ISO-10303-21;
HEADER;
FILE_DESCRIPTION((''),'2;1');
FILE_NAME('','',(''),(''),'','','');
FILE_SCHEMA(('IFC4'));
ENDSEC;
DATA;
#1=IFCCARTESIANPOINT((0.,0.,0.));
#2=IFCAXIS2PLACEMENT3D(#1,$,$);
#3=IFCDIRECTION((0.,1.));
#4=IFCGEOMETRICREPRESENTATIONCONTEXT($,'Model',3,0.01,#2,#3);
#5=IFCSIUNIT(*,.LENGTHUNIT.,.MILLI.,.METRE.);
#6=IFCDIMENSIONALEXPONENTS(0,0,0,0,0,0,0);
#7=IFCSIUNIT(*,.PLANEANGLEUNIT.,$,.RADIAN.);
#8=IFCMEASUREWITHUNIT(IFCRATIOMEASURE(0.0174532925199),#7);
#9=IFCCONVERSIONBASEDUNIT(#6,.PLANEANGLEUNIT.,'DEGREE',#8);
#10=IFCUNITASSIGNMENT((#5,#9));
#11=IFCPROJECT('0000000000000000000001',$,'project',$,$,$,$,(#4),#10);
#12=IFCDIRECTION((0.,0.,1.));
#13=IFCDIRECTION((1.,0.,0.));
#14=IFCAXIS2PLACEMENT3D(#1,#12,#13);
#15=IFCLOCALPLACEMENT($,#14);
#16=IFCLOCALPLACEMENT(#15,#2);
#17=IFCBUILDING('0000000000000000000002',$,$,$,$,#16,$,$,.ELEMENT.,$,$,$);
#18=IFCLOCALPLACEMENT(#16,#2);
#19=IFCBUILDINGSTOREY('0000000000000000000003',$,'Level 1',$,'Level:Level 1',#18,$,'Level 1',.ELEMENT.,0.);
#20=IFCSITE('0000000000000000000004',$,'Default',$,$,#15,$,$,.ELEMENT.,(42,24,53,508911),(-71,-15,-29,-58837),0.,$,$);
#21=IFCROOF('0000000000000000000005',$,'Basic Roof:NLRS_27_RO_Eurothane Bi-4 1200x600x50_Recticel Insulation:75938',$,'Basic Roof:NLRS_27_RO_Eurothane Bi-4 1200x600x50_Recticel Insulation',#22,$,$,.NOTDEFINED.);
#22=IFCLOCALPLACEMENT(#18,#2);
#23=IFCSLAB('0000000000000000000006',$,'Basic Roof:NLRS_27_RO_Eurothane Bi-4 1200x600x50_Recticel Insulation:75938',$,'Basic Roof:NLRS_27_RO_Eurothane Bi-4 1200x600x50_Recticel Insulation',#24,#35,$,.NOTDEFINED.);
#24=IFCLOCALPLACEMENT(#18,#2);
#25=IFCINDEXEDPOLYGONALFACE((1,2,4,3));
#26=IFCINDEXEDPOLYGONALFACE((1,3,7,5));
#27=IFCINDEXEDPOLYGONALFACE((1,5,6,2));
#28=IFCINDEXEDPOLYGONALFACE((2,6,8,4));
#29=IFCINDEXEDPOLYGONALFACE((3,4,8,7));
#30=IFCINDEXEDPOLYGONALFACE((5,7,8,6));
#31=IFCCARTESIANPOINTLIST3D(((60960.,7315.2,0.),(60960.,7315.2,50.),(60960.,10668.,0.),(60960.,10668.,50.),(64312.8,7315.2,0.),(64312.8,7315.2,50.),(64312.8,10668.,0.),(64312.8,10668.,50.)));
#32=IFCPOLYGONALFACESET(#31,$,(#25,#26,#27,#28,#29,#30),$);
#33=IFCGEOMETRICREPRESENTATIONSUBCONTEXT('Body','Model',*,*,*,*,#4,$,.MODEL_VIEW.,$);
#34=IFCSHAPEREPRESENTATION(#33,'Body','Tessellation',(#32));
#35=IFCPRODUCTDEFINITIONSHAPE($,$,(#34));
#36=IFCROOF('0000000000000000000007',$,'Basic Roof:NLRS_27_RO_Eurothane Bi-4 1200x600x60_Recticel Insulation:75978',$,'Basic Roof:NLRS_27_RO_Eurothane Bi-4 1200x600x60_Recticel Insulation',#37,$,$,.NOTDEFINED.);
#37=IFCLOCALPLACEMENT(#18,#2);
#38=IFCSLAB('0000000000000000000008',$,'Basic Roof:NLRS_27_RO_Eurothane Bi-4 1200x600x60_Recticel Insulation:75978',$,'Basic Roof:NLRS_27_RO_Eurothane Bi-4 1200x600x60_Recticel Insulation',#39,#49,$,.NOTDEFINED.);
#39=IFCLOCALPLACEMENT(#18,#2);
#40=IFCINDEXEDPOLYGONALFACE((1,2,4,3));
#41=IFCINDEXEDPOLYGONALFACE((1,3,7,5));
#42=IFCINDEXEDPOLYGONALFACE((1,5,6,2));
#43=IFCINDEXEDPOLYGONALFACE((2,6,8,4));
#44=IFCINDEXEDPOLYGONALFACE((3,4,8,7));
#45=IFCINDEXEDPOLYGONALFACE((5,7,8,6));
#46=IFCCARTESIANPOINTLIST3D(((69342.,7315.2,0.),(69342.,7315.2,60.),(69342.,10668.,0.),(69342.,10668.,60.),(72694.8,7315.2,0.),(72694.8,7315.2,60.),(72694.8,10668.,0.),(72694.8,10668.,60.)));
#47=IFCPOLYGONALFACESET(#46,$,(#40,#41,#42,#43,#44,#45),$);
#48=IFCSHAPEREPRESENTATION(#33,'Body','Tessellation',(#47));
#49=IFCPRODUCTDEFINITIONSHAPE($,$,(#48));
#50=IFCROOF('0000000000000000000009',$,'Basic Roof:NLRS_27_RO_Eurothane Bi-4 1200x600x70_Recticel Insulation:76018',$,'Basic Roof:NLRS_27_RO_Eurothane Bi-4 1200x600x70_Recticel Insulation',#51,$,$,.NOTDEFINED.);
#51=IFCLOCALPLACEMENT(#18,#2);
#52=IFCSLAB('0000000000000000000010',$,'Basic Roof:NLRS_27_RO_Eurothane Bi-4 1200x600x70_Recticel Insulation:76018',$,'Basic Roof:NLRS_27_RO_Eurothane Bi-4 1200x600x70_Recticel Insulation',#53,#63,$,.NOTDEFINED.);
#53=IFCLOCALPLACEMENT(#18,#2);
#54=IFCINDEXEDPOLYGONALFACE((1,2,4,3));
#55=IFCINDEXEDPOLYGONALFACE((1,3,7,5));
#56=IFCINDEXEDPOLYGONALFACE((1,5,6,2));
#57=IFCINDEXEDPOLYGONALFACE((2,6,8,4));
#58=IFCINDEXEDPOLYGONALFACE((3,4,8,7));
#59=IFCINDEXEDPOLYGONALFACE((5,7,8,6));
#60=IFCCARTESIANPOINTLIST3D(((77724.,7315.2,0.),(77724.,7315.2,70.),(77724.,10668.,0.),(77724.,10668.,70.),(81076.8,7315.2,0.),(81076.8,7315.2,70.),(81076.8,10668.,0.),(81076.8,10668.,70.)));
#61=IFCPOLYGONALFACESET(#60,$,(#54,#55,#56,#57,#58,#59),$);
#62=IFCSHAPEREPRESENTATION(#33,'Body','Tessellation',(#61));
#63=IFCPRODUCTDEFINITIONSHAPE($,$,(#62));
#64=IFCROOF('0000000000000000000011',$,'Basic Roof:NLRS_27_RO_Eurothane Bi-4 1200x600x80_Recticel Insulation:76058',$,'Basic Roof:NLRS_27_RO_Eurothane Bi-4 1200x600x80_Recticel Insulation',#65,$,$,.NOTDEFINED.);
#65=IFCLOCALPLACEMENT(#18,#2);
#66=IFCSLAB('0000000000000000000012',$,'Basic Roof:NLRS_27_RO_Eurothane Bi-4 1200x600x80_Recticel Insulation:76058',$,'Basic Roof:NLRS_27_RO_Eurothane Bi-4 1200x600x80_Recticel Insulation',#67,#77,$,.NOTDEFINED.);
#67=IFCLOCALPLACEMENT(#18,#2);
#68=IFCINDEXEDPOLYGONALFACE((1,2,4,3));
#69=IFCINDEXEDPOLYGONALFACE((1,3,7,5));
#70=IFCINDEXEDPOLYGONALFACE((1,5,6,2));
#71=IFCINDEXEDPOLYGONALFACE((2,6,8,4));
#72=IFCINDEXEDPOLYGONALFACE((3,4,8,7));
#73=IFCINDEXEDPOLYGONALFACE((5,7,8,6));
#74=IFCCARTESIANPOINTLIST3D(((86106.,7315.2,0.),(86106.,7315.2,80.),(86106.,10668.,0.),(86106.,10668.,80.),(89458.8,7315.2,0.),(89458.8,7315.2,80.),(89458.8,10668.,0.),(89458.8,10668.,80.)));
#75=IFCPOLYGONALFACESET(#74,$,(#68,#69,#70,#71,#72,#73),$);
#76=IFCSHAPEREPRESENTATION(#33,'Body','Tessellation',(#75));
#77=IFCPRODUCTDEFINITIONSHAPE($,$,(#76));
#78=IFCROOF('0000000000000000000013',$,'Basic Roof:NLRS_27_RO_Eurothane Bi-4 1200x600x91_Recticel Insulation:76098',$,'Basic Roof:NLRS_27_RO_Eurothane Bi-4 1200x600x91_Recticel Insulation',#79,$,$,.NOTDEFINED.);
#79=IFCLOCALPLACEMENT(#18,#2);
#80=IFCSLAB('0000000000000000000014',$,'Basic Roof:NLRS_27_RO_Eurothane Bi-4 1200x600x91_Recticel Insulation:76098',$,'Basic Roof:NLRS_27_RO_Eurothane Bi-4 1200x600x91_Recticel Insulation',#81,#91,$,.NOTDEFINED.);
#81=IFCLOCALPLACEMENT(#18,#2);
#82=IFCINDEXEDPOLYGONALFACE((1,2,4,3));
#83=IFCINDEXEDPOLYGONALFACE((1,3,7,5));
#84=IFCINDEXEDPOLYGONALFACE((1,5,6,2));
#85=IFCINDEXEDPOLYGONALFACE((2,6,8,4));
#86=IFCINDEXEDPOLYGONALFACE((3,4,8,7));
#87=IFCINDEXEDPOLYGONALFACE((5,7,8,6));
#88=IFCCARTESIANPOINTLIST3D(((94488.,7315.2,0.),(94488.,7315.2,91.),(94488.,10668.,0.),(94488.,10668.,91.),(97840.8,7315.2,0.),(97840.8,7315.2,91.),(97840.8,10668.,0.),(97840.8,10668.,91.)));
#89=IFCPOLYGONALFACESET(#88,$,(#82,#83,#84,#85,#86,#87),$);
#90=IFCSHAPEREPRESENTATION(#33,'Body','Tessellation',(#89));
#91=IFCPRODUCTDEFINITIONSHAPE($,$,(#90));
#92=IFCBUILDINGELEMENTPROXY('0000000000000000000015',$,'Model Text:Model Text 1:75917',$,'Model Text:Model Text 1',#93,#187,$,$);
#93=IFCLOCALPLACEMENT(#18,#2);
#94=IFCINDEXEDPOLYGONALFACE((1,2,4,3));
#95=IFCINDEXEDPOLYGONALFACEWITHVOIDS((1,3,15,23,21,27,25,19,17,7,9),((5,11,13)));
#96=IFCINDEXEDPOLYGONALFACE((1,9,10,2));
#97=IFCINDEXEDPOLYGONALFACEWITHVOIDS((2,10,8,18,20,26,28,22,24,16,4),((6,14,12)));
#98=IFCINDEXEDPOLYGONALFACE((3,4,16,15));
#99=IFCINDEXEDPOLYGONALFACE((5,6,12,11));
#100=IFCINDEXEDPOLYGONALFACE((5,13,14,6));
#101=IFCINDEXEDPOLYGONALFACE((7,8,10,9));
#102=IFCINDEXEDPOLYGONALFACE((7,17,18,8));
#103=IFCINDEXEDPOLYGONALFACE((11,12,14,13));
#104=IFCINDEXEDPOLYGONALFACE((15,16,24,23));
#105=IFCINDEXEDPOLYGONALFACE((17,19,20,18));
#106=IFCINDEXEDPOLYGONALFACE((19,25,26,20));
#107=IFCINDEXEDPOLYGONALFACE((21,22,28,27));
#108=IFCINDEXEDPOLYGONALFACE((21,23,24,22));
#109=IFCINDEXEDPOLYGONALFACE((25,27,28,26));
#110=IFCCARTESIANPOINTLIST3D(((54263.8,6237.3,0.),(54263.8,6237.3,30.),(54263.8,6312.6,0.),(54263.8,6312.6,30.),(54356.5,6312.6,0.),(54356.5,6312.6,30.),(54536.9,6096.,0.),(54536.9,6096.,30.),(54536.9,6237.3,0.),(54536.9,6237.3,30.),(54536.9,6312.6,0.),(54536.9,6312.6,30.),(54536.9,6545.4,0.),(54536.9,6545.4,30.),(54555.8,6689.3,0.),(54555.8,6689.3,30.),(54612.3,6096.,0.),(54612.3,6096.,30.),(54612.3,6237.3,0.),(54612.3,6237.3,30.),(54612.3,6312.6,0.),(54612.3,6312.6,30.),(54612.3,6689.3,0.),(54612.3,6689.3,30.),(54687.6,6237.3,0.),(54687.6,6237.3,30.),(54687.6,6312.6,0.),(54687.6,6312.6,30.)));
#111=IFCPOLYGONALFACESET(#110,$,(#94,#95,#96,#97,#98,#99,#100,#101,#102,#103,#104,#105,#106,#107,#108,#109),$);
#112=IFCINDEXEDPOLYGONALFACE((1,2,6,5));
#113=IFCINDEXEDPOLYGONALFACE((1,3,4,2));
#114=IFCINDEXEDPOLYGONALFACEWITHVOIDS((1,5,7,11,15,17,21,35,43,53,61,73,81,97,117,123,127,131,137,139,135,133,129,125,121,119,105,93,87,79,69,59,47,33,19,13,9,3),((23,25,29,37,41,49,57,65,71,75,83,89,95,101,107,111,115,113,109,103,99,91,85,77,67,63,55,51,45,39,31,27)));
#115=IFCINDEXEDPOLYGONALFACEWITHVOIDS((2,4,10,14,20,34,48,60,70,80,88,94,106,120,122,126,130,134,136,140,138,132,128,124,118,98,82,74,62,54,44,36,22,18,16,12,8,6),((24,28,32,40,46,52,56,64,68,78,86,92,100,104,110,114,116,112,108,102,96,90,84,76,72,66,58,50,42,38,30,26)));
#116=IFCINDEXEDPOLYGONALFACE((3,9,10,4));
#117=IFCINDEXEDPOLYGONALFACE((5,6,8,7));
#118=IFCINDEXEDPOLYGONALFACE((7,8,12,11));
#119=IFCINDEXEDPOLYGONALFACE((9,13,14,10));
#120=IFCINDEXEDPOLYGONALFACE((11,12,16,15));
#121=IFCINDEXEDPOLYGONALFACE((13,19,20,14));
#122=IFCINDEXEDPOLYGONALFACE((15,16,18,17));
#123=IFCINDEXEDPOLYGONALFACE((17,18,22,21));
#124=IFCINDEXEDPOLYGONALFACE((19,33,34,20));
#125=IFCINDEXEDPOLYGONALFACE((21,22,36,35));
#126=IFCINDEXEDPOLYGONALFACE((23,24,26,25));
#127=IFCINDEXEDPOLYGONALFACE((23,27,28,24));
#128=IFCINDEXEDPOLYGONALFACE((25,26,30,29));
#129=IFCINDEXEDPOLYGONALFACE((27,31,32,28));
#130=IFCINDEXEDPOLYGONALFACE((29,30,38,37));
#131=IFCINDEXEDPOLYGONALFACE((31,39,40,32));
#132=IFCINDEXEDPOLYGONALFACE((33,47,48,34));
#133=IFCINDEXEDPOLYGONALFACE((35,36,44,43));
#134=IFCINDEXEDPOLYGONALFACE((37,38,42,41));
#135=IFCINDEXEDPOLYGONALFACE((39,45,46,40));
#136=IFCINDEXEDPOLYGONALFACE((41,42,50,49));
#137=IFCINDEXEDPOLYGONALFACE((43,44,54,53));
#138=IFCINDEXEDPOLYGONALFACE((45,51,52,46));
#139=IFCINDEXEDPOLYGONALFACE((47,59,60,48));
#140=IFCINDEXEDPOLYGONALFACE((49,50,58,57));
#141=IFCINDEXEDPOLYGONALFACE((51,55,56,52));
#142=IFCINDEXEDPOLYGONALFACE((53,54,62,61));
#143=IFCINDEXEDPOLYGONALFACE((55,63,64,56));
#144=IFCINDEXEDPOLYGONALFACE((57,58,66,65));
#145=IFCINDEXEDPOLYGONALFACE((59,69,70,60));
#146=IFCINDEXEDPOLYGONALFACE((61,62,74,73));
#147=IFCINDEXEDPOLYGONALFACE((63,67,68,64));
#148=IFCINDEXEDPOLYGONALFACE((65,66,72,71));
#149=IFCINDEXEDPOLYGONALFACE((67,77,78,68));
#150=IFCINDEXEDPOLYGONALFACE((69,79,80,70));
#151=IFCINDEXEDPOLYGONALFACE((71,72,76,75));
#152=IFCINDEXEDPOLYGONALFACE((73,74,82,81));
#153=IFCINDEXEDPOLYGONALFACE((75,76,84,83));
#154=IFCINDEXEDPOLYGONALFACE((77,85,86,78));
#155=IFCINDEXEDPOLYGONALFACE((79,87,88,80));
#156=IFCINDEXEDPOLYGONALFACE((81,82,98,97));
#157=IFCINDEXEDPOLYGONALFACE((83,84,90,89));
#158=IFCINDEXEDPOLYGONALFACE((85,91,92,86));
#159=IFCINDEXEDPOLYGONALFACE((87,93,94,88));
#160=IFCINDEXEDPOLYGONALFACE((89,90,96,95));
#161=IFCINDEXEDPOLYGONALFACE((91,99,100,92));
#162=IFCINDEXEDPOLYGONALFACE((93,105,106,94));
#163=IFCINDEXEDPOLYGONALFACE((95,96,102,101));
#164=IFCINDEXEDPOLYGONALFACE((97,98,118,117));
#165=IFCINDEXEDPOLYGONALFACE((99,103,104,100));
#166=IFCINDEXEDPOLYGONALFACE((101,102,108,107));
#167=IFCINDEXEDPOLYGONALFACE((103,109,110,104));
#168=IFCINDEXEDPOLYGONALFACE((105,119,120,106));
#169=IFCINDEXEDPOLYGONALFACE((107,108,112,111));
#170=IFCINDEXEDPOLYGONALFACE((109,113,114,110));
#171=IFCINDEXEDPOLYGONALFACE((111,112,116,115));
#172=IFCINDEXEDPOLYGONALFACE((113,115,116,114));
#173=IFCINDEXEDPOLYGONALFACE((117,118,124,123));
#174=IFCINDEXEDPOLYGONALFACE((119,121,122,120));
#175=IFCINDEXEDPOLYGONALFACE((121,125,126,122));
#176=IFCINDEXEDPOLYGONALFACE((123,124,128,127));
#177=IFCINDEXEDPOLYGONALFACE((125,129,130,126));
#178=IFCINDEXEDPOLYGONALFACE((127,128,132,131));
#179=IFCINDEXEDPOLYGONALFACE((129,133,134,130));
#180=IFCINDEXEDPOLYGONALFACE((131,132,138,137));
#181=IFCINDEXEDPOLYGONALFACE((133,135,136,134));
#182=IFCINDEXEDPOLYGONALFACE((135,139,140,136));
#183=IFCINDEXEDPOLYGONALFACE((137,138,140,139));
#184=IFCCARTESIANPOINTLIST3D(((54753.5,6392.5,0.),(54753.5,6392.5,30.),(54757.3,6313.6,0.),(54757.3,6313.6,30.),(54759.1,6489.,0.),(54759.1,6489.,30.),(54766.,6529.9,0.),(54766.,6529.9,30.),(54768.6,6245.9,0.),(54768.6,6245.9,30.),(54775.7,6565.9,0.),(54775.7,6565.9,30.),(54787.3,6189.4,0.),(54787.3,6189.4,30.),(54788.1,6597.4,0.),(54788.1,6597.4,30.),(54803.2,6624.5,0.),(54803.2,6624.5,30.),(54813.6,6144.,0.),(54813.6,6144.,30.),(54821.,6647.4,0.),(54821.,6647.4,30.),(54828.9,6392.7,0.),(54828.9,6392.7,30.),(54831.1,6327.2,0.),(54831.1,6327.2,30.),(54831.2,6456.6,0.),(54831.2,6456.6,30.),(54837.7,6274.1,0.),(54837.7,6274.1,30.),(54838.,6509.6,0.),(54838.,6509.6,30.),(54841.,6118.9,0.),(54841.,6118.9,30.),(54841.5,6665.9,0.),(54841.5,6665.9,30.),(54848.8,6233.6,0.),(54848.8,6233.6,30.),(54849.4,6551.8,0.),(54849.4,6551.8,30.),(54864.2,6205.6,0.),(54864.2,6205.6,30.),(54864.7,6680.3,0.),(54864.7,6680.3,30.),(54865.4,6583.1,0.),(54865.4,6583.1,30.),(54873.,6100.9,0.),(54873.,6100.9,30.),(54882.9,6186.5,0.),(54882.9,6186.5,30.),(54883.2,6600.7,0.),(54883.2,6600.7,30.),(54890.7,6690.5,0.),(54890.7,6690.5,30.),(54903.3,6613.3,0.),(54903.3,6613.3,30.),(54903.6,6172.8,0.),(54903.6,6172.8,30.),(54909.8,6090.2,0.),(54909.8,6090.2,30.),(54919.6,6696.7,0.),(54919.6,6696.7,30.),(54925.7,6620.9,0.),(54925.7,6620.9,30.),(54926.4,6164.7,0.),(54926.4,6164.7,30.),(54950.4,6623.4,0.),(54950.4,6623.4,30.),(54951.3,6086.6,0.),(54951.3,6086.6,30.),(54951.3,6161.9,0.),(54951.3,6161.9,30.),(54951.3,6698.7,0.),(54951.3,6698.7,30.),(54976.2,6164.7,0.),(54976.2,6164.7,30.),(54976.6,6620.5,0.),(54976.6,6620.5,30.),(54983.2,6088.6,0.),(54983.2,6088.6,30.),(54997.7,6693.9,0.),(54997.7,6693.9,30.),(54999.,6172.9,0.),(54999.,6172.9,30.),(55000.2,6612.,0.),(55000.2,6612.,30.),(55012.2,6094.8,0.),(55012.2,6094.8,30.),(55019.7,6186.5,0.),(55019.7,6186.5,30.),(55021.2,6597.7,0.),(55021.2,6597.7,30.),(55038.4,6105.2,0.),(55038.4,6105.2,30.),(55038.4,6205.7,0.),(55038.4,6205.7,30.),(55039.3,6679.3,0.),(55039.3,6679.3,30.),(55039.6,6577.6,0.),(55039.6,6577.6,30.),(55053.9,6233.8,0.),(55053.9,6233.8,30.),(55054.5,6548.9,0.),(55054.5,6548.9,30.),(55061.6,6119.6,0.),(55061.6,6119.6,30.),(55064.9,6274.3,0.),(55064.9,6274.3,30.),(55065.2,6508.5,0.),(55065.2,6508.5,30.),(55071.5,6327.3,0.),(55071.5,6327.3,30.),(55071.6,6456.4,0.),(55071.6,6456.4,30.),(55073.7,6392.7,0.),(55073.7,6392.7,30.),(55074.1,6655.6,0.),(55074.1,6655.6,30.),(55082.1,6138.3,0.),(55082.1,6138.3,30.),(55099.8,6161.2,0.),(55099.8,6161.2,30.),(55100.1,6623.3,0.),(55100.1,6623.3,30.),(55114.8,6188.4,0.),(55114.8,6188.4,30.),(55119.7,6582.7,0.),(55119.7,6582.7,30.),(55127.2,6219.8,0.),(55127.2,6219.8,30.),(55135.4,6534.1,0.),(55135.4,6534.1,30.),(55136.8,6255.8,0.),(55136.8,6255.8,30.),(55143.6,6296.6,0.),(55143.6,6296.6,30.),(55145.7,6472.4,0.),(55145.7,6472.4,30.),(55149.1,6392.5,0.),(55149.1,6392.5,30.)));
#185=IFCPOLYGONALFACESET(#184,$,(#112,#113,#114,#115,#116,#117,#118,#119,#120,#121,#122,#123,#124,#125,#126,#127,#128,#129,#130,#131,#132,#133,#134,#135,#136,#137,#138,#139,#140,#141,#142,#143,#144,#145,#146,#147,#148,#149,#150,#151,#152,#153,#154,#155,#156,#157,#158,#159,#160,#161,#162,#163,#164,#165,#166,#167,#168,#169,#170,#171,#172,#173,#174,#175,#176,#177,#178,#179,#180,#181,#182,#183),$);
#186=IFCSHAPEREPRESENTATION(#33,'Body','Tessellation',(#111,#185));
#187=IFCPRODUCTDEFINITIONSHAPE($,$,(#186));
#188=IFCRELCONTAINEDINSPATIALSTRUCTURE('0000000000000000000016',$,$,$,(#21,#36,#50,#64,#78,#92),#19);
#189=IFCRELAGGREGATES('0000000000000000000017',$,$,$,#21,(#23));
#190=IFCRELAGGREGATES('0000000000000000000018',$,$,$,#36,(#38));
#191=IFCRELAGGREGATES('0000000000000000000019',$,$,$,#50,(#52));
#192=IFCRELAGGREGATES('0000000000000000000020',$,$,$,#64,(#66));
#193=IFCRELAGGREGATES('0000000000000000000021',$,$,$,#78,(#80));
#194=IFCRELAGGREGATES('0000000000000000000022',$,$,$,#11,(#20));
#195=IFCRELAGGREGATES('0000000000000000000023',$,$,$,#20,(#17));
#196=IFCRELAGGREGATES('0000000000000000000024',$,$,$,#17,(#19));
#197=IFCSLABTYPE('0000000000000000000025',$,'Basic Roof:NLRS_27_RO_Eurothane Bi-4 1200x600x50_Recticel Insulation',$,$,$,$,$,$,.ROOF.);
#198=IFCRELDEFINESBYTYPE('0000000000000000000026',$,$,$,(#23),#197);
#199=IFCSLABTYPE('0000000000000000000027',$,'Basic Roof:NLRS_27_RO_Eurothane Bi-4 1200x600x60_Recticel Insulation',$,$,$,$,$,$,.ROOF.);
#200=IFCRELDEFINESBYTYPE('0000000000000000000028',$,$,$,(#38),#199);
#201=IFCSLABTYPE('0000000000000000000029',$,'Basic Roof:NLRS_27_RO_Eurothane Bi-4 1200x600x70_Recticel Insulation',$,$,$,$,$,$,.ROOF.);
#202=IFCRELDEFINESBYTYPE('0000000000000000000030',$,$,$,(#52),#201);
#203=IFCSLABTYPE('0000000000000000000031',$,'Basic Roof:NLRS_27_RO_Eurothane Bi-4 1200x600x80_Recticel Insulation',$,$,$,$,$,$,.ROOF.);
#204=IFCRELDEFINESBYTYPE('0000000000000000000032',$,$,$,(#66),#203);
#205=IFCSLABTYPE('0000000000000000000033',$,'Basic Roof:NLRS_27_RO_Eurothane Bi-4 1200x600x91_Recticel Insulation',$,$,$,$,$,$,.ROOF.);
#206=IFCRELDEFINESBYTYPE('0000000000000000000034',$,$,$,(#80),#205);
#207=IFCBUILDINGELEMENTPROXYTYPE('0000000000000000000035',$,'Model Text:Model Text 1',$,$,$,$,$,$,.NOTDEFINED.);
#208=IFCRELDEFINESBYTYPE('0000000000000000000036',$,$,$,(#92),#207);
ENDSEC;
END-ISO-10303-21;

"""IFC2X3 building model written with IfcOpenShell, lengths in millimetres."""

from ifc_helpers import new_model, entity, si_unit, converted_unit, direction, frame, origin, origin_with_axes, origin_2d_with_axis, place, context, subcontext, project, spatial, polyline, rectangle, outline, extrude, type_object, element, aggregate, save


model = new_model("IFC2X3")

# Units and contexts
model_context = context("Model", 3, precision=0.01, world=origin(), true_north=direction((0.0, 1.0)))
body_context = subcontext(model_context, "Body", "Model", "MODEL_VIEW")
ifc_project = project(units=[si_unit("LENGTHUNIT", "METRE", prefix="MILLI"), converted_unit("PLANEANGLEUNIT", "DEGREE", entity("IfcRatioMeasure", 0.0174532925199), si_unit("PLANEANGLEUNIT", "RADIAN"), dimensions=[0, 0, 0, 0, 0, 0, 0])], contexts=[model_context])

# Site, building, storey
site_placement = place(None, origin_with_axes())
site = spatial("IfcSite", under=ifc_project, at=site_placement, Name="Default", CompositionType="ELEMENT", RefLatitude=(42, 24, 53, 508911), RefLongitude=(-71, -15, -29, -58837), RefElevation=0.0)
building_placement = place(site_placement, origin())
building = spatial("IfcBuilding", under=site, at=building_placement, CompositionType="ELEMENT")
storey_placement = place(building_placement, origin())
storey = spatial("IfcBuildingStorey", under=building, at=storey_placement, Name="Level 1", ObjectType="Level:Level 1", LongName="Level 1", CompositionType="ELEMENT", Elevation=0.0)

# Roofs, slabs
roof_1_placement = place(storey_placement, frame((60960.0, 7315.2, 0.0)))
roof_1 = element("IfcRoof", 1, at=roof_1_placement, inside=storey, Name="Basic Roof:NLRS_27_RO_Eurothane Bi-4 1200x600x50_Recticel Insulation:75938", ObjectType="Basic Roof:NLRS_27_RO_Eurothane Bi-4 1200x600x50_Recticel Insulation", ShapeType="NOTDEFINED")
slab_type_1 = type_object("IfcSlabType", Name="Basic Roof:NLRS_27_RO_Eurothane Bi-4 1200x600x50_Recticel Insulation", PredefinedType="ROOF")
slab_1_placement = place(roof_1_placement, origin())
slab_1 = element("IfcSlab", 2, at=slab_1_placement, type_object=slab_type_1, Name="Basic Roof:NLRS_27_RO_Eurothane Bi-4 1200x600x50_Recticel Insulation:75938", ObjectType="Basic Roof:NLRS_27_RO_Eurothane Bi-4 1200x600x50_Recticel Insulation", PredefinedType="NOTDEFINED", context=body_context, shape_type="SweptSolid", body=[
    extrude(rectangle(XDim=3352.8, YDim=3352.8, at=origin_2d_with_axis()), frame((1676.4, 1676.4, 0.0), x_axis=(-1.0, 0.0, 0.0)), (0.0, 0.0, 1.0), 50.0),
])
aggregate(roof_1, [slab_1])
roof_2_placement = place(storey_placement, frame((69342.0, 7315.2, 0.0)))
roof_2 = element("IfcRoof", 3, at=roof_2_placement, inside=storey, Name="Basic Roof:NLRS_27_RO_Eurothane Bi-4 1200x600x60_Recticel Insulation:75978", ObjectType="Basic Roof:NLRS_27_RO_Eurothane Bi-4 1200x600x60_Recticel Insulation", ShapeType="NOTDEFINED")
slab_type_2 = type_object("IfcSlabType", Name="Basic Roof:NLRS_27_RO_Eurothane Bi-4 1200x600x60_Recticel Insulation", PredefinedType="ROOF")
slab_2_placement = place(roof_2_placement, origin())
slab_2 = element("IfcSlab", 4, at=slab_2_placement, type_object=slab_type_2, Name="Basic Roof:NLRS_27_RO_Eurothane Bi-4 1200x600x60_Recticel Insulation:75978", ObjectType="Basic Roof:NLRS_27_RO_Eurothane Bi-4 1200x600x60_Recticel Insulation", PredefinedType="NOTDEFINED", context=body_context, shape_type="SweptSolid", body=[
    extrude(rectangle(XDim=3352.8, YDim=3352.8, at=origin_2d_with_axis()), frame((1676.4, 1676.4, 0.0), x_axis=(-1.0, 0.0, 0.0)), (0.0, 0.0, 1.0), 60.0),
])
aggregate(roof_2, [slab_2])
roof_3_placement = place(storey_placement, frame((77724.0, 7315.2, 0.0)))
roof_3 = element("IfcRoof", 5, at=roof_3_placement, inside=storey, Name="Basic Roof:NLRS_27_RO_Eurothane Bi-4 1200x600x70_Recticel Insulation:76018", ObjectType="Basic Roof:NLRS_27_RO_Eurothane Bi-4 1200x600x70_Recticel Insulation", ShapeType="NOTDEFINED")
slab_type_3 = type_object("IfcSlabType", Name="Basic Roof:NLRS_27_RO_Eurothane Bi-4 1200x600x70_Recticel Insulation", PredefinedType="ROOF")
slab_3_placement = place(roof_3_placement, origin())
slab_3 = element("IfcSlab", 6, at=slab_3_placement, type_object=slab_type_3, Name="Basic Roof:NLRS_27_RO_Eurothane Bi-4 1200x600x70_Recticel Insulation:76018", ObjectType="Basic Roof:NLRS_27_RO_Eurothane Bi-4 1200x600x70_Recticel Insulation", PredefinedType="NOTDEFINED", context=body_context, shape_type="SweptSolid", body=[
    extrude(rectangle(XDim=3352.8, YDim=3352.8, at=origin_2d_with_axis()), frame((1676.4, 1676.4, 0.0), x_axis=(-1.0, 0.0, 0.0)), (0.0, 0.0, 1.0), 70.0),
])
aggregate(roof_3, [slab_3])
roof_4_placement = place(storey_placement, frame((86106.0, 7315.2, 0.0)))
roof_4 = element("IfcRoof", 7, at=roof_4_placement, inside=storey, Name="Basic Roof:NLRS_27_RO_Eurothane Bi-4 1200x600x80_Recticel Insulation:76058", ObjectType="Basic Roof:NLRS_27_RO_Eurothane Bi-4 1200x600x80_Recticel Insulation", ShapeType="NOTDEFINED")
slab_type_4 = type_object("IfcSlabType", Name="Basic Roof:NLRS_27_RO_Eurothane Bi-4 1200x600x80_Recticel Insulation", PredefinedType="ROOF")
slab_4_placement = place(roof_4_placement, origin())
slab_4 = element("IfcSlab", 8, at=slab_4_placement, type_object=slab_type_4, Name="Basic Roof:NLRS_27_RO_Eurothane Bi-4 1200x600x80_Recticel Insulation:76058", ObjectType="Basic Roof:NLRS_27_RO_Eurothane Bi-4 1200x600x80_Recticel Insulation", PredefinedType="NOTDEFINED", context=body_context, shape_type="SweptSolid", body=[
    extrude(rectangle(XDim=3352.8, YDim=3352.8, at=origin_2d_with_axis()), frame((1676.4, 1676.4, 0.0), x_axis=(-1.0, 0.0, 0.0)), (0.0, 0.0, 1.0), 80.0),
])
aggregate(roof_4, [slab_4])
roof_5_placement = place(storey_placement, frame((94488.0, 7315.2, 0.0)))
roof_5 = element("IfcRoof", 9, at=roof_5_placement, inside=storey, Name="Basic Roof:NLRS_27_RO_Eurothane Bi-4 1200x600x91_Recticel Insulation:76098", ObjectType="Basic Roof:NLRS_27_RO_Eurothane Bi-4 1200x600x91_Recticel Insulation", ShapeType="NOTDEFINED")
slab_type_5 = type_object("IfcSlabType", Name="Basic Roof:NLRS_27_RO_Eurothane Bi-4 1200x600x91_Recticel Insulation", PredefinedType="ROOF")
slab_5_placement = place(roof_5_placement, origin())
slab_5 = element("IfcSlab", 10, at=slab_5_placement, type_object=slab_type_5, Name="Basic Roof:NLRS_27_RO_Eurothane Bi-4 1200x600x91_Recticel Insulation:76098", ObjectType="Basic Roof:NLRS_27_RO_Eurothane Bi-4 1200x600x91_Recticel Insulation", PredefinedType="NOTDEFINED", context=body_context, shape_type="SweptSolid", body=[
    extrude(rectangle(XDim=3352.8, YDim=3352.8, at=origin_2d_with_axis()), frame((1676.4, 1676.4, 0.0), x_axis=(-1.0, 0.0, 0.0)), (0.0, 0.0, 1.0), 91.0),
])
aggregate(roof_5, [slab_5])

# Building element proxy
building_element_proxy_type_1 = type_object("IfcBuildingElementProxyType", Name="Model Text:Model Text 1", PredefinedType="NOTDEFINED")
proxy_1_placement = place(storey_placement, frame((54263.8, 6086.6, 0.0)))
element("IfcBuildingElementProxy", 11, at=proxy_1_placement, inside=storey, type_object=building_element_proxy_type_1, Name="Model Text:Model Text 1:75917", ObjectType="Model Text:Model Text 1", context=body_context, shape_type="SweptSolid", body=[
    extrude(outline(polyline([(-6.8, -218.3), (68.5, -218.3), (68.5, -77.1), (143.8, -77.1), (143.8, -1.7), (68.5, -1.7), (68.5, 375.0), (12.0, 375.0), (-280.0, -1.7), (-280.0, -77.1), (-6.8, -77.1), (-6.8, -218.3)]), holes=[polyline([(-6.8, -1.7), (-187.3, -1.7), (-6.8, 231.1), (-6.8, -1.7)])]), frame((280.0, 227.7, 0.0)), (0.0, 0.0, 1.0), 30.0),
    extrude(outline(polyline([(-10.6, -198.7), (68.3, -198.7), (136.5, -190.7), (193.9, -174.7), (240.5, -150.6), (266.9, -124.4), (286.3, -93.2), (298.8, -57.0), (304.3, -15.7), (303.8, 16.2), (299.0, 45.5), (289.9, 72.1), (276.6, 96.0), (258.9, 117.3), (236.9, 136.2), (210.4, 152.5), (179.6, 166.3), (144.1, 177.6), (103.7, 186.3), (8.2, 196.4), (-71.8, 196.7), (-134.0, 189.4), (-183.3, 176.1), (-224.7, 158.4), (-258.2, 133.9), (-283.5, 100.3), (-300.1, 59.5), (-307.1, 13.4), (-306.6, -18.4), (-301.8, -47.5), (-292.8, -74.0), (-279.6, -97.9), (-262.0, -119.2), (-240.0, -138.1), (-213.6, -154.5), (-182.8, -168.4), (-147.3, -179.8), (-106.7, -188.6), (-10.6, -198.7)]), holes=[polyline([(-7.2, -123.5), (-71.0, -118.2), (-123.6, -108.8), (-165.2, -95.4), (-195.7, -78.0), (-212.4, -59.4), (-224.1, -38.7), (-230.6, -15.9), (-231.9, 8.9), (-227.8, 35.0), (-218.1, 58.1), (-202.8, 78.4), (-182.0, 95.8), (-152.6, 109.4), (-111.7, 118.1), (-59.4, 122.0), (4.4, 121.1), (69.6, 115.8), (122.2, 106.7), (162.2, 93.7), (189.5, 77.0), (207.7, 57.4), (220.4, 36.0), (227.5, 12.8), (229.1, -12.1), (225.2, -36.8), (215.9, -59.2), (201.3, -79.3), (181.4, -97.1), (152.6, -111.2), (111.6, -120.3), (58.3, -124.4), (-7.2, -123.5)])]), frame((688.7, 304.7, 0.0), z_axis=(0.0, 0.0, 1.0), x_axis=(0.047515, -0.998871, 0.0)), (0.0, 0.0, 1.0), 30.0),
])

save(model, "model.ifc")
